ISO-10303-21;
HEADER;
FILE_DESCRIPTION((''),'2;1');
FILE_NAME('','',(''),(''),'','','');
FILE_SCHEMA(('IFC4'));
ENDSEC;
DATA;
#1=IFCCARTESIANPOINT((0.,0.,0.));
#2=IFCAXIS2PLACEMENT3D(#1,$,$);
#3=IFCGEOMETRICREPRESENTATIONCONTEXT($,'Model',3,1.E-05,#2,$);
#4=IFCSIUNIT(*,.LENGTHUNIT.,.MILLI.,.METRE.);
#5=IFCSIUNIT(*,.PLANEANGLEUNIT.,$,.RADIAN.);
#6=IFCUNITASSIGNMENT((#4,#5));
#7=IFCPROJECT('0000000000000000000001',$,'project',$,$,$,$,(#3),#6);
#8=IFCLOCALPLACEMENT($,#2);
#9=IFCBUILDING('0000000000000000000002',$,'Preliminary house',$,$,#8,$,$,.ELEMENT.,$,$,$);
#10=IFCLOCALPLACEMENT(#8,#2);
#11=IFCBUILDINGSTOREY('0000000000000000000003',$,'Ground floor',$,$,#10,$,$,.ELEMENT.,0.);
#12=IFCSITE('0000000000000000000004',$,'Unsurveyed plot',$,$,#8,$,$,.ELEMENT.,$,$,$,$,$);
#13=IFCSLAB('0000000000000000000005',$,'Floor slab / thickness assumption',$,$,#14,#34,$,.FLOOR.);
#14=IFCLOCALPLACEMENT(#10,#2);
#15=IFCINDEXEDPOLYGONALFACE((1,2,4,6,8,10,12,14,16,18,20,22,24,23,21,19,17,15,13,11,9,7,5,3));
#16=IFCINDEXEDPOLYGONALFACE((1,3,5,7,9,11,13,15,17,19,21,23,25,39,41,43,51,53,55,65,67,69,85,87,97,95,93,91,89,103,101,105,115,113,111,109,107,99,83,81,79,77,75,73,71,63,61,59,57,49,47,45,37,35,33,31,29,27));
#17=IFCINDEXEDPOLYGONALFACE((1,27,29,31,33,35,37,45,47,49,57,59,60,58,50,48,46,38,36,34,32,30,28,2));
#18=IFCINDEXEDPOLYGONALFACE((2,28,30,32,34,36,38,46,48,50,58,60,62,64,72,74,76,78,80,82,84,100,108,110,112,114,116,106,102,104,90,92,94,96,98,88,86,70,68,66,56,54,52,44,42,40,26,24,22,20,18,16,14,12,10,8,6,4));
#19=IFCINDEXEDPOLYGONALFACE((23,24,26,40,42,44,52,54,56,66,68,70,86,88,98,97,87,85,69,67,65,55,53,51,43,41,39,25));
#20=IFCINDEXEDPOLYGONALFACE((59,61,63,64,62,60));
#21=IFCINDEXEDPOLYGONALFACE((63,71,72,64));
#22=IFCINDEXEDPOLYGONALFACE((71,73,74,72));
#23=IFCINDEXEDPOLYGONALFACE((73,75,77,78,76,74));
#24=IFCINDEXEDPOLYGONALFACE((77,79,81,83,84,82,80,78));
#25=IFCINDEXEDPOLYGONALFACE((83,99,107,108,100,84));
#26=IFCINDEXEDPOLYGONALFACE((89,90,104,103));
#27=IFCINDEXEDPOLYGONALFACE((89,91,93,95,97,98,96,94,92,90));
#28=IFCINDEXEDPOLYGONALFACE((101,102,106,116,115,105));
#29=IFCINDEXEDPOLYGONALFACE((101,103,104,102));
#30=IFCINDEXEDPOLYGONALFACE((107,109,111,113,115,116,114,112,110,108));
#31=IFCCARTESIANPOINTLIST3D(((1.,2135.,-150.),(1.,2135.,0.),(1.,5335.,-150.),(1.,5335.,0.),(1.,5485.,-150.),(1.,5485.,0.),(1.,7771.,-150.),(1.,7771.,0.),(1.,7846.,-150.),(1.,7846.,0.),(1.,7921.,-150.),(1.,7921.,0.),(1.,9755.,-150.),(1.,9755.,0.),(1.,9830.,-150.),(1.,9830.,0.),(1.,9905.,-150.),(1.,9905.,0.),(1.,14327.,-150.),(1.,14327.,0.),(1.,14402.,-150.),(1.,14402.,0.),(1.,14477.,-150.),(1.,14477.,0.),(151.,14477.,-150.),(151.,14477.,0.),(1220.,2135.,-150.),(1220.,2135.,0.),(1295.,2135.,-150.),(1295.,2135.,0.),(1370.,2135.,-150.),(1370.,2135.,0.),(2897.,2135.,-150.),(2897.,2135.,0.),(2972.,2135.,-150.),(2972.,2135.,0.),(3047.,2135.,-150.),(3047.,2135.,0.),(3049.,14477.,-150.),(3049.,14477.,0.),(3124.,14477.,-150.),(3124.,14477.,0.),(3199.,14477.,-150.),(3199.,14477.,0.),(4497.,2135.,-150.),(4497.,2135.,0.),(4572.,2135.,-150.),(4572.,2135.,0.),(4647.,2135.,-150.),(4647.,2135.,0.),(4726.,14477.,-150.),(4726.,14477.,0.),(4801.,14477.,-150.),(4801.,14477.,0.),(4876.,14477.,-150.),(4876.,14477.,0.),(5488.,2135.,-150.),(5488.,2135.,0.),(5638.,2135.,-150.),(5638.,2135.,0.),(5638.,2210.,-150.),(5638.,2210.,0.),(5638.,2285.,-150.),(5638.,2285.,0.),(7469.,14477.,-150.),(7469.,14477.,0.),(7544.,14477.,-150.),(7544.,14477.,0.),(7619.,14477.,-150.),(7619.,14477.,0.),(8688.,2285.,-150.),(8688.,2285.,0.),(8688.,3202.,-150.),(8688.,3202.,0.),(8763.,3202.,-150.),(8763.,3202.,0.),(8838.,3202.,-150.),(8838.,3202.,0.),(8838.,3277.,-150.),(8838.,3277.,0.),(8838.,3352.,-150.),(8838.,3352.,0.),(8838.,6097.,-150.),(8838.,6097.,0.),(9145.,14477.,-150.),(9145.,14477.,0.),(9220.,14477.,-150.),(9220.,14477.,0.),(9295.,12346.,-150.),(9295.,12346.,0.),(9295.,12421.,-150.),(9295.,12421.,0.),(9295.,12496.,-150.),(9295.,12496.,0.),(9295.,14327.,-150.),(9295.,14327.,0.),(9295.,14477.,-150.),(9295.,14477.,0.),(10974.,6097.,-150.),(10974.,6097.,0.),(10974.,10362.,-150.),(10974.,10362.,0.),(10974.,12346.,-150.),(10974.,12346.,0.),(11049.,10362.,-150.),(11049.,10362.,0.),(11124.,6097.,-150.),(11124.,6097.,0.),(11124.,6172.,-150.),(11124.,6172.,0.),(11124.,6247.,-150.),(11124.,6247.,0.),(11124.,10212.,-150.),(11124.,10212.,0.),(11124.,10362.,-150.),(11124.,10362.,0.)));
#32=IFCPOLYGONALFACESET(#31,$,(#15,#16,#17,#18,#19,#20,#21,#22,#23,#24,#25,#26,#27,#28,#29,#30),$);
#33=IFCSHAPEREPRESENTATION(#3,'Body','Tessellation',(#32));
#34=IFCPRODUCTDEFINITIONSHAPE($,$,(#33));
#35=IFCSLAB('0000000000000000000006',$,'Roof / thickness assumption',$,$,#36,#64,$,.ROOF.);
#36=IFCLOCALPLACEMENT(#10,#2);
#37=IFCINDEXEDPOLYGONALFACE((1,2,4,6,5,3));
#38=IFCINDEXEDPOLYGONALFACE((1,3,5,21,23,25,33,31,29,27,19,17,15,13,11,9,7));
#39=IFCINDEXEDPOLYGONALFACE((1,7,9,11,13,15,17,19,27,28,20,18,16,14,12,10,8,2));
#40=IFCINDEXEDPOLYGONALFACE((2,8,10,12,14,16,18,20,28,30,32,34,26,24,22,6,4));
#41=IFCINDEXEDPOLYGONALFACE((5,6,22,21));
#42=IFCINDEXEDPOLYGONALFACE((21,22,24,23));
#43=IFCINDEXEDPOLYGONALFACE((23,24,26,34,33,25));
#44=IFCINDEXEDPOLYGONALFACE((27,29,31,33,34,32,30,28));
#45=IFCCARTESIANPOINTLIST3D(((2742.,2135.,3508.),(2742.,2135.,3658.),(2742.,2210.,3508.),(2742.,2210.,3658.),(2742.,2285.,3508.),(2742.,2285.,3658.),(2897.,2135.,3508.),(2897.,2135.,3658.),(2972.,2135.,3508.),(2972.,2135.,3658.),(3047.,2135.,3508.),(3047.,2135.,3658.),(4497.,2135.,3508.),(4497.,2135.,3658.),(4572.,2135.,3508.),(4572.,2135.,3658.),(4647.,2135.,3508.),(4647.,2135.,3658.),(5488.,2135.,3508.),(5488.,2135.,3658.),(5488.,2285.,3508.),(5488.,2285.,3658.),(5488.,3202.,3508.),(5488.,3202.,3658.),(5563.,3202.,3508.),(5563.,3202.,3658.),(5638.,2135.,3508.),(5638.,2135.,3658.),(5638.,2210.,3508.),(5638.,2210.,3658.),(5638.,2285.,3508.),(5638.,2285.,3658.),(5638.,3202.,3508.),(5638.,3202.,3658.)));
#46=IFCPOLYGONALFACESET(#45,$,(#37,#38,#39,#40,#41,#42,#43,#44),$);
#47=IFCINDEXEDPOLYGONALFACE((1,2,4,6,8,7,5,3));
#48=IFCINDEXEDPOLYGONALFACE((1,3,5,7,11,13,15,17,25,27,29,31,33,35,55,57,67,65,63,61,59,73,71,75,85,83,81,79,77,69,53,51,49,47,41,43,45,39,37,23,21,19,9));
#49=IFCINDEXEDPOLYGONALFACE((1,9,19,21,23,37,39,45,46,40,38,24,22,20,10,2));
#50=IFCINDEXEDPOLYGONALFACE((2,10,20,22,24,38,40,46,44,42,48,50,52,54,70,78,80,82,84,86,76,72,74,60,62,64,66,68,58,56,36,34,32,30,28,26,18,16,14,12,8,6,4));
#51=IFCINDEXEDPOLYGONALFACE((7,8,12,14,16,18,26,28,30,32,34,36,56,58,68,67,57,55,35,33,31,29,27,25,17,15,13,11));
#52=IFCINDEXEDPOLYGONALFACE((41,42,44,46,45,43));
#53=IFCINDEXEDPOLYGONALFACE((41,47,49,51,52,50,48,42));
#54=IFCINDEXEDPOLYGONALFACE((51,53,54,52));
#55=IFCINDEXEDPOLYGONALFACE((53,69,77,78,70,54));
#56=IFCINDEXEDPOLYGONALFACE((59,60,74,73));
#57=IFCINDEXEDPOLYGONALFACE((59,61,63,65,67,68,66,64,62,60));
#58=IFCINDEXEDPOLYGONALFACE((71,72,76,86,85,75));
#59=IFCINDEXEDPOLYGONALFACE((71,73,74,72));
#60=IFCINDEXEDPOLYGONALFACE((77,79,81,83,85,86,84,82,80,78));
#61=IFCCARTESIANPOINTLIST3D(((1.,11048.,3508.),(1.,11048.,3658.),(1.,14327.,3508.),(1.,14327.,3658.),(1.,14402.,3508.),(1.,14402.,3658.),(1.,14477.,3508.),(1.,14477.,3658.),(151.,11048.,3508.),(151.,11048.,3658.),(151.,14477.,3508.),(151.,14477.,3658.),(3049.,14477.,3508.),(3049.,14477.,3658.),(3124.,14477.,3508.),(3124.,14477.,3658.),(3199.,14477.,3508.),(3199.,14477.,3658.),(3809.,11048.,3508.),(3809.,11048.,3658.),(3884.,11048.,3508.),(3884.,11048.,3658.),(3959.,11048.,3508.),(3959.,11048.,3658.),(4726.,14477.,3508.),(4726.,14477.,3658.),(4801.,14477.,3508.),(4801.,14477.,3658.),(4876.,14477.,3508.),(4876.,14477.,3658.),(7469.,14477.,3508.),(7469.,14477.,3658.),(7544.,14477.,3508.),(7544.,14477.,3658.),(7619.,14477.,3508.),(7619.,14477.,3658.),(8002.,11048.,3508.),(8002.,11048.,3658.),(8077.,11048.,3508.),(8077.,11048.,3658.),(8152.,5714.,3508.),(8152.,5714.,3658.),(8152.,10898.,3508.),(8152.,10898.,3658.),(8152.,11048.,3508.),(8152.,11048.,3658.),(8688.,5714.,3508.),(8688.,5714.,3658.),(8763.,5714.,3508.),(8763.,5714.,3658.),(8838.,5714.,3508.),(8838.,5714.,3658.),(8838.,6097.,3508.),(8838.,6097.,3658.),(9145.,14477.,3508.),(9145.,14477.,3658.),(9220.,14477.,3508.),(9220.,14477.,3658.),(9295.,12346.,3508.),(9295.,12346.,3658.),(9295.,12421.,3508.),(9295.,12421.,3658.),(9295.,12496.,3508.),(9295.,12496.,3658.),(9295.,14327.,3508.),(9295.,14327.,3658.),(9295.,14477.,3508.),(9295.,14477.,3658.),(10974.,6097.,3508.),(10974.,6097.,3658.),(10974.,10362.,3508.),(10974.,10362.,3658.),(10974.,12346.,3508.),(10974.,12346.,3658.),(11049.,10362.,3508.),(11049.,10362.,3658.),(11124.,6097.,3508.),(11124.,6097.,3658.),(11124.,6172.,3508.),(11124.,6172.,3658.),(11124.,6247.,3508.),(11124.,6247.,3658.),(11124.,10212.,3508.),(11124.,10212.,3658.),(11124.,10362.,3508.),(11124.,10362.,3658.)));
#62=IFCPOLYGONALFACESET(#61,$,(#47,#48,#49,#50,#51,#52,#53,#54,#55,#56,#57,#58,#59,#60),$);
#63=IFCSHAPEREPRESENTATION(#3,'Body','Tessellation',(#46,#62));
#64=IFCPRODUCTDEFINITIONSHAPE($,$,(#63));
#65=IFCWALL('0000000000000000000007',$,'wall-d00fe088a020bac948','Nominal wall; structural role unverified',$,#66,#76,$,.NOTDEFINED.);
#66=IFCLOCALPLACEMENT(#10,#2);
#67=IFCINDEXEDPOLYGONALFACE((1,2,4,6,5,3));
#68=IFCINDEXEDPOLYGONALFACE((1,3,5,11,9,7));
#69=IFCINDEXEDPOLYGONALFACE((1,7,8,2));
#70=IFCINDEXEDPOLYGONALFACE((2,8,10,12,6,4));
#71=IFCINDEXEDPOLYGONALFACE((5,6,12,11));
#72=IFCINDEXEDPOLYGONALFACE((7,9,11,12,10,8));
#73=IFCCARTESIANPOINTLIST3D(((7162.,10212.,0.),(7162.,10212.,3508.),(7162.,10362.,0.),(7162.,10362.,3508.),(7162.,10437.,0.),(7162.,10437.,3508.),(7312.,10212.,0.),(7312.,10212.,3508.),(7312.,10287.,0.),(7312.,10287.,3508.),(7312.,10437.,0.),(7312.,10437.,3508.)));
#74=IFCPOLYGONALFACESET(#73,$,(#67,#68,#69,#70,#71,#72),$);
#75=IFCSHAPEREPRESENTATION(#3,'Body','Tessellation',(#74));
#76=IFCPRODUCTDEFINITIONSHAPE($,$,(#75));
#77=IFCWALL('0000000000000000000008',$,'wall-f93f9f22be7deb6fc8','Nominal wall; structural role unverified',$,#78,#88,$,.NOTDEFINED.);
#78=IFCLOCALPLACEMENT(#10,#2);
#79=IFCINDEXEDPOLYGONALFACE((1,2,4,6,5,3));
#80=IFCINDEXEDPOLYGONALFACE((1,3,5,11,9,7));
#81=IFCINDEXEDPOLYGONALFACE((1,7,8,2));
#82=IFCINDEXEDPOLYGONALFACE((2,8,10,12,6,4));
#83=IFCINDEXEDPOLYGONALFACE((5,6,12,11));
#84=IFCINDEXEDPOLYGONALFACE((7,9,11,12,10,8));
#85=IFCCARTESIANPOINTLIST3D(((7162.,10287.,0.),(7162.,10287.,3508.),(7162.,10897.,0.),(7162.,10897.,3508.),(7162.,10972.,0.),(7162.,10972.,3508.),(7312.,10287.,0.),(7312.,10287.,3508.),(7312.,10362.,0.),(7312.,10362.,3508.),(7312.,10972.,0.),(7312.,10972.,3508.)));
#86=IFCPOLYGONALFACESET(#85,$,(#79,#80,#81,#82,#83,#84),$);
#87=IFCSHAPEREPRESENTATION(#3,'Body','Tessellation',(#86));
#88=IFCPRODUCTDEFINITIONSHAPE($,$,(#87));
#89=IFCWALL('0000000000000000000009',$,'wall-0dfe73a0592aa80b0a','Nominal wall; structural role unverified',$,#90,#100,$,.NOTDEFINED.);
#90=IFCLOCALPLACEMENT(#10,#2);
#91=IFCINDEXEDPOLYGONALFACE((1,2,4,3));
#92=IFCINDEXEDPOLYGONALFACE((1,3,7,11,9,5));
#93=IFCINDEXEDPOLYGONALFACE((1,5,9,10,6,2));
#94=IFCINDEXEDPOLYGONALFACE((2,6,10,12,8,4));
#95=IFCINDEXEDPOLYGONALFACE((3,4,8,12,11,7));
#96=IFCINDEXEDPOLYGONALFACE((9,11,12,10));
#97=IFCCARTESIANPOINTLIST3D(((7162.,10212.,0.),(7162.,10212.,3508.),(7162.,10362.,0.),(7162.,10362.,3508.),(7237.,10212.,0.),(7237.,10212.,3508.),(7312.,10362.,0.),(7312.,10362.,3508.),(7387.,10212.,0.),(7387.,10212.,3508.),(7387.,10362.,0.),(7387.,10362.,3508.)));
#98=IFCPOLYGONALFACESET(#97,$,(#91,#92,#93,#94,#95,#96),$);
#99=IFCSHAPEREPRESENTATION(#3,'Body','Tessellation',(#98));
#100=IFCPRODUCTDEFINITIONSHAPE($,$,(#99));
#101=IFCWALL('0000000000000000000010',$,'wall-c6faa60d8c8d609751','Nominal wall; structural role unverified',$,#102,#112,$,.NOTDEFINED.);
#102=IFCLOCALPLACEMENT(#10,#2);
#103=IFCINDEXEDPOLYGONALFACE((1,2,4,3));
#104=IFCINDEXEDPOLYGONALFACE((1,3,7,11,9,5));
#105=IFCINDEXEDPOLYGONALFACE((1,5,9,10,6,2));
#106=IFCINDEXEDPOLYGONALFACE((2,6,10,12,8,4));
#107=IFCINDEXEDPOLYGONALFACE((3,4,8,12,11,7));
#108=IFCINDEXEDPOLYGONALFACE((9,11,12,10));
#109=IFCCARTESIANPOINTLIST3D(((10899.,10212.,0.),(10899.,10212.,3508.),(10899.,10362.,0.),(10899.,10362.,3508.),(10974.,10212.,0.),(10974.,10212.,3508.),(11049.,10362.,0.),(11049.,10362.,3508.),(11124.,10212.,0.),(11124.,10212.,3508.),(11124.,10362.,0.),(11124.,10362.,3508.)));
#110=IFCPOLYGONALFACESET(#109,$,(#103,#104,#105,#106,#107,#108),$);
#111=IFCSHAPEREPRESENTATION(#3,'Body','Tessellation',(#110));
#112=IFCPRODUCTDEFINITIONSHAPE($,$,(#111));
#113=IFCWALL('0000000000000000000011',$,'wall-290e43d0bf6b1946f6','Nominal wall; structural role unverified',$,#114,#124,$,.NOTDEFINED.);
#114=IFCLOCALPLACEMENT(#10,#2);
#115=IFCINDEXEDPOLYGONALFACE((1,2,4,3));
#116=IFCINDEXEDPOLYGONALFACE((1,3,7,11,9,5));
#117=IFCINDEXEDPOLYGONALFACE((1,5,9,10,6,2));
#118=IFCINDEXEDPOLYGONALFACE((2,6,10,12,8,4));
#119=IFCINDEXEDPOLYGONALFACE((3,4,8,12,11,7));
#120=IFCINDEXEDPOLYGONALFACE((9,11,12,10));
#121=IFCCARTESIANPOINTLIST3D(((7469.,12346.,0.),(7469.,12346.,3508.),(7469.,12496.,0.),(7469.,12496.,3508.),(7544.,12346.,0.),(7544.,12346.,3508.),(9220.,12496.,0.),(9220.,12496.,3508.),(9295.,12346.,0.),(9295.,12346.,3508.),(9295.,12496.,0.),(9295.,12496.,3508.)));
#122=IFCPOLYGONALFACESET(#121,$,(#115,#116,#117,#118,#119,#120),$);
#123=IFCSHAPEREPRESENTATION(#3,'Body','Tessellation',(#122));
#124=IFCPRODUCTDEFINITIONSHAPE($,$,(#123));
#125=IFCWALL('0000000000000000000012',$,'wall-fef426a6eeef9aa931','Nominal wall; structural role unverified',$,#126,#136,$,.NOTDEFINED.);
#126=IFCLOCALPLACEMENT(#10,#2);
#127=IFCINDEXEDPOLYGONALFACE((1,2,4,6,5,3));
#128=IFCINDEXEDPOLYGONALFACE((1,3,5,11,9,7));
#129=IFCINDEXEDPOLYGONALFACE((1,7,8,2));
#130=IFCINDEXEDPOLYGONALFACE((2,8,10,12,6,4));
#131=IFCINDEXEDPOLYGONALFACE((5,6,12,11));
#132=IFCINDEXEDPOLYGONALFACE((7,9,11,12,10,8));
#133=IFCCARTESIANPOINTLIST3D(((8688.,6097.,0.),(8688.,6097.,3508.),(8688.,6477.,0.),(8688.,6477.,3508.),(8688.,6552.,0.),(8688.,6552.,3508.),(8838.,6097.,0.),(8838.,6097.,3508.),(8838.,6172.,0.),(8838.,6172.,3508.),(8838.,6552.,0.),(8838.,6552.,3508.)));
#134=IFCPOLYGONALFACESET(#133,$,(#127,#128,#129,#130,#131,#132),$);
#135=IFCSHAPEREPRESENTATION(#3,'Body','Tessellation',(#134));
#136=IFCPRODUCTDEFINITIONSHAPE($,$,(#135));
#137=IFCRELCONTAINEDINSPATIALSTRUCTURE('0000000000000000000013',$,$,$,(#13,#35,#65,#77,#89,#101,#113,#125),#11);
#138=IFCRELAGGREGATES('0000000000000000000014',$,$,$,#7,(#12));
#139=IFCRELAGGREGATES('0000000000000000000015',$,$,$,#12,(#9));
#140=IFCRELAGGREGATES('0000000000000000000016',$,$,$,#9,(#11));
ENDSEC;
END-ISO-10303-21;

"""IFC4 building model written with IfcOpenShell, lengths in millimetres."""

from ifc_helpers import new_model, si_unit, frame, origin, place, context, project, spatial, polyline, outline, extrude, element, save


model = new_model("IFC4")

# Units and contexts
model_context = context("Model", 3, precision=1e-05, world=origin())
ifc_project = project(units=[si_unit("LENGTHUNIT", "METRE", prefix="MILLI"), si_unit("PLANEANGLEUNIT", "RADIAN")], contexts=[model_context])

# Site, building, storey
placement_1 = place(None, origin())
site = spatial("IfcSite", under=ifc_project, at=placement_1, Name="Unsurveyed plot", CompositionType="ELEMENT")
building = spatial("IfcBuilding", under=site, at=placement_1, Name="Preliminary house", CompositionType="ELEMENT")
placement_2 = place(placement_1, origin())
storey = spatial("IfcBuildingStorey", under=building, at=placement_2, Name="Ground floor", CompositionType="ELEMENT", Elevation=0.0)

# Slabs
element("IfcSlab", 1, at=placement_2, inside=storey, Name="Floor slab / thickness assumption", PredefinedType="FLOOR", context=model_context, shape_type="SweptSolid", body=[
    extrude(outline(polyline([(4497.0, 2135.0), (3047.0, 2135.0), (2972.0, 2135.0), (2897.0, 2135.0), (1370.0, 2135.0), (1295.0, 2135.0), (1220.0, 2135.0), (1.0, 2135.0), (1.0, 5335.0), (1.0, 5485.0), (1.0, 7771.0), (1.0, 7846.0), (1.0, 7921.0), (1.0, 9755.0), (1.0, 9830.0), (1.0, 9905.0), (1.0, 14327.0), (1.0, 14402.0), (1.0, 14477.0), (151.0, 14477.0), (3049.0, 14477.0), (3124.0, 14477.0), (3199.0, 14477.0), (4726.0, 14477.0), (4801.0, 14477.0), (4876.0, 14477.0), (7469.0, 14477.0), (7544.0, 14477.0), (7619.0, 14477.0), (9145.0, 14477.0), (9220.0, 14477.0), (9295.0, 14477.0), (9295.0, 14327.0), (9295.0, 12496.0), (9295.0, 12421.0), (9295.0, 12346.0), (10974.0, 12346.0), (10974.0, 10362.0), (11049.0, 10362.0), (11124.0, 10362.0), (11124.0, 10212.0), (11124.0, 6247.0), (11124.0, 6172.0), (11124.0, 6097.0), (10974.0, 6097.0), (8838.0, 6097.0), (8838.0, 3352.0), (8838.0, 3277.0), (8838.0, 3202.0), (8763.0, 3202.0), (8688.0, 3202.0), (8688.0, 2285.0), (5638.0, 2285.0), (5638.0, 2210.0), (5638.0, 2135.0), (5488.0, 2135.0), (4647.0, 2135.0), (4572.0, 2135.0), (4497.0, 2135.0)])), frame((0.0, 0.0, -150.0)), (0.0, 0.0, 1.0), 150.0),
])
element("IfcSlab", 2, at=placement_2, inside=storey, Name="Roof / thickness assumption", PredefinedType="ROOF", context=model_context, shape_type="SweptSolid", body=[
    extrude(outline(polyline([(2742.0, 2210.0), (2742.0, 2285.0), (5488.0, 2285.0), (5488.0, 3202.0), (5563.0, 3202.0), (5638.0, 3202.0), (5638.0, 2285.0), (5638.0, 2210.0), (5638.0, 2135.0), (5488.0, 2135.0), (4647.0, 2135.0), (4572.0, 2135.0), (4497.0, 2135.0), (3047.0, 2135.0), (2972.0, 2135.0), (2897.0, 2135.0), (2742.0, 2135.0), (2742.0, 2210.0)])), frame((0.0, 0.0, 3508.0)), (0.0, 0.0, 1.0), 150.0),
    extrude(outline(polyline([(1.0, 14402.0), (1.0, 14477.0), (151.0, 14477.0), (3049.0, 14477.0), (3124.0, 14477.0), (3199.0, 14477.0), (4726.0, 14477.0), (4801.0, 14477.0), (4876.0, 14477.0), (7469.0, 14477.0), (7544.0, 14477.0), (7619.0, 14477.0), (9145.0, 14477.0), (9220.0, 14477.0), (9295.0, 14477.0), (9295.0, 14327.0), (9295.0, 12496.0), (9295.0, 12421.0), (9295.0, 12346.0), (10974.0, 12346.0), (10974.0, 10362.0), (11049.0, 10362.0), (11124.0, 10362.0), (11124.0, 10212.0), (11124.0, 6247.0), (11124.0, 6172.0), (11124.0, 6097.0), (10974.0, 6097.0), (8838.0, 6097.0), (8838.0, 5714.0), (8763.0, 5714.0), (8688.0, 5714.0), (8152.0, 5714.0), (8152.0, 10898.0), (8152.0, 11048.0), (8077.0, 11048.0), (8002.0, 11048.0), (3959.0, 11048.0), (3884.0, 11048.0), (3809.0, 11048.0), (151.0, 11048.0), (1.0, 11048.0), (1.0, 14327.0), (1.0, 14402.0)])), frame((0.0, 0.0, 3508.0)), (0.0, 0.0, 1.0), 150.0),
])

# Walls
element("IfcWall", 3, at=placement_2, inside=storey, Name="wall-d00fe088a020bac948", Description="Nominal wall; structural role unverified", PredefinedType="NOTDEFINED", context=model_context, shape_type="SweptSolid", body=[
    extrude(outline(polyline([(7162.0, 10362.0), (7162.0, 10437.0), (7312.0, 10437.0), (7312.0, 10287.0), (7312.0, 10212.0), (7162.0, 10212.0), (7162.0, 10362.0)])), origin(), (0.0, 0.0, 1.0), 3508.0),
])
element("IfcWall", 4, at=placement_2, inside=storey, Name="wall-f93f9f22be7deb6fc8", Description="Nominal wall; structural role unverified", PredefinedType="NOTDEFINED", context=model_context, shape_type="SweptSolid", body=[
    extrude(outline(polyline([(7162.0, 10897.0), (7162.0, 10972.0), (7312.0, 10972.0), (7312.0, 10362.0), (7312.0, 10287.0), (7162.0, 10287.0), (7162.0, 10897.0)])), origin(), (0.0, 0.0, 1.0), 3508.0),
])
element("IfcWall", 5, at=placement_2, inside=storey, Name="wall-0dfe73a0592aa80b0a", Description="Nominal wall; structural role unverified", PredefinedType="NOTDEFINED", context=model_context, shape_type="SweptSolid", body=[
    extrude(outline(polyline([(7312.0, 10362.0), (7387.0, 10362.0), (7387.0, 10212.0), (7237.0, 10212.0), (7162.0, 10212.0), (7162.0, 10362.0), (7312.0, 10362.0)])), origin(), (0.0, 0.0, 1.0), 3508.0),
])

# Wall
element("IfcWall", 6, at=placement_2, inside=storey, Name="wall-c6faa60d8c8d609751", Description="Nominal wall; structural role unverified", PredefinedType="NOTDEFINED", context=model_context, shape_type="SweptSolid", body=[
    extrude(outline(polyline([(11049.0, 10362.0), (11124.0, 10362.0), (11124.0, 10212.0), (10974.0, 10212.0), (10899.0, 10212.0), (10899.0, 10362.0), (11049.0, 10362.0)])), origin(), (0.0, 0.0, 1.0), 3508.0),
])

# Wall
element("IfcWall", 7, at=placement_2, inside=storey, Name="wall-290e43d0bf6b1946f6", Description="Nominal wall; structural role unverified", PredefinedType="NOTDEFINED", context=model_context, shape_type="SweptSolid", body=[
    extrude(outline(polyline([(9220.0, 12496.0), (9295.0, 12496.0), (9295.0, 12346.0), (7544.0, 12346.0), (7469.0, 12346.0), (7469.0, 12496.0), (9220.0, 12496.0)])), origin(), (0.0, 0.0, 1.0), 3508.0),
])

# Wall
element("IfcWall", 8, at=placement_2, inside=storey, Name="wall-fef426a6eeef9aa931", Description="Nominal wall; structural role unverified", PredefinedType="NOTDEFINED", context=model_context, shape_type="SweptSolid", body=[
    extrude(outline(polyline([(8688.0, 6477.0), (8688.0, 6552.0), (8838.0, 6552.0), (8838.0, 6172.0), (8838.0, 6097.0), (8688.0, 6097.0), (8688.0, 6477.0)])), origin(), (0.0, 0.0, 1.0), 3508.0),
])

save(model, "model.ifc")
